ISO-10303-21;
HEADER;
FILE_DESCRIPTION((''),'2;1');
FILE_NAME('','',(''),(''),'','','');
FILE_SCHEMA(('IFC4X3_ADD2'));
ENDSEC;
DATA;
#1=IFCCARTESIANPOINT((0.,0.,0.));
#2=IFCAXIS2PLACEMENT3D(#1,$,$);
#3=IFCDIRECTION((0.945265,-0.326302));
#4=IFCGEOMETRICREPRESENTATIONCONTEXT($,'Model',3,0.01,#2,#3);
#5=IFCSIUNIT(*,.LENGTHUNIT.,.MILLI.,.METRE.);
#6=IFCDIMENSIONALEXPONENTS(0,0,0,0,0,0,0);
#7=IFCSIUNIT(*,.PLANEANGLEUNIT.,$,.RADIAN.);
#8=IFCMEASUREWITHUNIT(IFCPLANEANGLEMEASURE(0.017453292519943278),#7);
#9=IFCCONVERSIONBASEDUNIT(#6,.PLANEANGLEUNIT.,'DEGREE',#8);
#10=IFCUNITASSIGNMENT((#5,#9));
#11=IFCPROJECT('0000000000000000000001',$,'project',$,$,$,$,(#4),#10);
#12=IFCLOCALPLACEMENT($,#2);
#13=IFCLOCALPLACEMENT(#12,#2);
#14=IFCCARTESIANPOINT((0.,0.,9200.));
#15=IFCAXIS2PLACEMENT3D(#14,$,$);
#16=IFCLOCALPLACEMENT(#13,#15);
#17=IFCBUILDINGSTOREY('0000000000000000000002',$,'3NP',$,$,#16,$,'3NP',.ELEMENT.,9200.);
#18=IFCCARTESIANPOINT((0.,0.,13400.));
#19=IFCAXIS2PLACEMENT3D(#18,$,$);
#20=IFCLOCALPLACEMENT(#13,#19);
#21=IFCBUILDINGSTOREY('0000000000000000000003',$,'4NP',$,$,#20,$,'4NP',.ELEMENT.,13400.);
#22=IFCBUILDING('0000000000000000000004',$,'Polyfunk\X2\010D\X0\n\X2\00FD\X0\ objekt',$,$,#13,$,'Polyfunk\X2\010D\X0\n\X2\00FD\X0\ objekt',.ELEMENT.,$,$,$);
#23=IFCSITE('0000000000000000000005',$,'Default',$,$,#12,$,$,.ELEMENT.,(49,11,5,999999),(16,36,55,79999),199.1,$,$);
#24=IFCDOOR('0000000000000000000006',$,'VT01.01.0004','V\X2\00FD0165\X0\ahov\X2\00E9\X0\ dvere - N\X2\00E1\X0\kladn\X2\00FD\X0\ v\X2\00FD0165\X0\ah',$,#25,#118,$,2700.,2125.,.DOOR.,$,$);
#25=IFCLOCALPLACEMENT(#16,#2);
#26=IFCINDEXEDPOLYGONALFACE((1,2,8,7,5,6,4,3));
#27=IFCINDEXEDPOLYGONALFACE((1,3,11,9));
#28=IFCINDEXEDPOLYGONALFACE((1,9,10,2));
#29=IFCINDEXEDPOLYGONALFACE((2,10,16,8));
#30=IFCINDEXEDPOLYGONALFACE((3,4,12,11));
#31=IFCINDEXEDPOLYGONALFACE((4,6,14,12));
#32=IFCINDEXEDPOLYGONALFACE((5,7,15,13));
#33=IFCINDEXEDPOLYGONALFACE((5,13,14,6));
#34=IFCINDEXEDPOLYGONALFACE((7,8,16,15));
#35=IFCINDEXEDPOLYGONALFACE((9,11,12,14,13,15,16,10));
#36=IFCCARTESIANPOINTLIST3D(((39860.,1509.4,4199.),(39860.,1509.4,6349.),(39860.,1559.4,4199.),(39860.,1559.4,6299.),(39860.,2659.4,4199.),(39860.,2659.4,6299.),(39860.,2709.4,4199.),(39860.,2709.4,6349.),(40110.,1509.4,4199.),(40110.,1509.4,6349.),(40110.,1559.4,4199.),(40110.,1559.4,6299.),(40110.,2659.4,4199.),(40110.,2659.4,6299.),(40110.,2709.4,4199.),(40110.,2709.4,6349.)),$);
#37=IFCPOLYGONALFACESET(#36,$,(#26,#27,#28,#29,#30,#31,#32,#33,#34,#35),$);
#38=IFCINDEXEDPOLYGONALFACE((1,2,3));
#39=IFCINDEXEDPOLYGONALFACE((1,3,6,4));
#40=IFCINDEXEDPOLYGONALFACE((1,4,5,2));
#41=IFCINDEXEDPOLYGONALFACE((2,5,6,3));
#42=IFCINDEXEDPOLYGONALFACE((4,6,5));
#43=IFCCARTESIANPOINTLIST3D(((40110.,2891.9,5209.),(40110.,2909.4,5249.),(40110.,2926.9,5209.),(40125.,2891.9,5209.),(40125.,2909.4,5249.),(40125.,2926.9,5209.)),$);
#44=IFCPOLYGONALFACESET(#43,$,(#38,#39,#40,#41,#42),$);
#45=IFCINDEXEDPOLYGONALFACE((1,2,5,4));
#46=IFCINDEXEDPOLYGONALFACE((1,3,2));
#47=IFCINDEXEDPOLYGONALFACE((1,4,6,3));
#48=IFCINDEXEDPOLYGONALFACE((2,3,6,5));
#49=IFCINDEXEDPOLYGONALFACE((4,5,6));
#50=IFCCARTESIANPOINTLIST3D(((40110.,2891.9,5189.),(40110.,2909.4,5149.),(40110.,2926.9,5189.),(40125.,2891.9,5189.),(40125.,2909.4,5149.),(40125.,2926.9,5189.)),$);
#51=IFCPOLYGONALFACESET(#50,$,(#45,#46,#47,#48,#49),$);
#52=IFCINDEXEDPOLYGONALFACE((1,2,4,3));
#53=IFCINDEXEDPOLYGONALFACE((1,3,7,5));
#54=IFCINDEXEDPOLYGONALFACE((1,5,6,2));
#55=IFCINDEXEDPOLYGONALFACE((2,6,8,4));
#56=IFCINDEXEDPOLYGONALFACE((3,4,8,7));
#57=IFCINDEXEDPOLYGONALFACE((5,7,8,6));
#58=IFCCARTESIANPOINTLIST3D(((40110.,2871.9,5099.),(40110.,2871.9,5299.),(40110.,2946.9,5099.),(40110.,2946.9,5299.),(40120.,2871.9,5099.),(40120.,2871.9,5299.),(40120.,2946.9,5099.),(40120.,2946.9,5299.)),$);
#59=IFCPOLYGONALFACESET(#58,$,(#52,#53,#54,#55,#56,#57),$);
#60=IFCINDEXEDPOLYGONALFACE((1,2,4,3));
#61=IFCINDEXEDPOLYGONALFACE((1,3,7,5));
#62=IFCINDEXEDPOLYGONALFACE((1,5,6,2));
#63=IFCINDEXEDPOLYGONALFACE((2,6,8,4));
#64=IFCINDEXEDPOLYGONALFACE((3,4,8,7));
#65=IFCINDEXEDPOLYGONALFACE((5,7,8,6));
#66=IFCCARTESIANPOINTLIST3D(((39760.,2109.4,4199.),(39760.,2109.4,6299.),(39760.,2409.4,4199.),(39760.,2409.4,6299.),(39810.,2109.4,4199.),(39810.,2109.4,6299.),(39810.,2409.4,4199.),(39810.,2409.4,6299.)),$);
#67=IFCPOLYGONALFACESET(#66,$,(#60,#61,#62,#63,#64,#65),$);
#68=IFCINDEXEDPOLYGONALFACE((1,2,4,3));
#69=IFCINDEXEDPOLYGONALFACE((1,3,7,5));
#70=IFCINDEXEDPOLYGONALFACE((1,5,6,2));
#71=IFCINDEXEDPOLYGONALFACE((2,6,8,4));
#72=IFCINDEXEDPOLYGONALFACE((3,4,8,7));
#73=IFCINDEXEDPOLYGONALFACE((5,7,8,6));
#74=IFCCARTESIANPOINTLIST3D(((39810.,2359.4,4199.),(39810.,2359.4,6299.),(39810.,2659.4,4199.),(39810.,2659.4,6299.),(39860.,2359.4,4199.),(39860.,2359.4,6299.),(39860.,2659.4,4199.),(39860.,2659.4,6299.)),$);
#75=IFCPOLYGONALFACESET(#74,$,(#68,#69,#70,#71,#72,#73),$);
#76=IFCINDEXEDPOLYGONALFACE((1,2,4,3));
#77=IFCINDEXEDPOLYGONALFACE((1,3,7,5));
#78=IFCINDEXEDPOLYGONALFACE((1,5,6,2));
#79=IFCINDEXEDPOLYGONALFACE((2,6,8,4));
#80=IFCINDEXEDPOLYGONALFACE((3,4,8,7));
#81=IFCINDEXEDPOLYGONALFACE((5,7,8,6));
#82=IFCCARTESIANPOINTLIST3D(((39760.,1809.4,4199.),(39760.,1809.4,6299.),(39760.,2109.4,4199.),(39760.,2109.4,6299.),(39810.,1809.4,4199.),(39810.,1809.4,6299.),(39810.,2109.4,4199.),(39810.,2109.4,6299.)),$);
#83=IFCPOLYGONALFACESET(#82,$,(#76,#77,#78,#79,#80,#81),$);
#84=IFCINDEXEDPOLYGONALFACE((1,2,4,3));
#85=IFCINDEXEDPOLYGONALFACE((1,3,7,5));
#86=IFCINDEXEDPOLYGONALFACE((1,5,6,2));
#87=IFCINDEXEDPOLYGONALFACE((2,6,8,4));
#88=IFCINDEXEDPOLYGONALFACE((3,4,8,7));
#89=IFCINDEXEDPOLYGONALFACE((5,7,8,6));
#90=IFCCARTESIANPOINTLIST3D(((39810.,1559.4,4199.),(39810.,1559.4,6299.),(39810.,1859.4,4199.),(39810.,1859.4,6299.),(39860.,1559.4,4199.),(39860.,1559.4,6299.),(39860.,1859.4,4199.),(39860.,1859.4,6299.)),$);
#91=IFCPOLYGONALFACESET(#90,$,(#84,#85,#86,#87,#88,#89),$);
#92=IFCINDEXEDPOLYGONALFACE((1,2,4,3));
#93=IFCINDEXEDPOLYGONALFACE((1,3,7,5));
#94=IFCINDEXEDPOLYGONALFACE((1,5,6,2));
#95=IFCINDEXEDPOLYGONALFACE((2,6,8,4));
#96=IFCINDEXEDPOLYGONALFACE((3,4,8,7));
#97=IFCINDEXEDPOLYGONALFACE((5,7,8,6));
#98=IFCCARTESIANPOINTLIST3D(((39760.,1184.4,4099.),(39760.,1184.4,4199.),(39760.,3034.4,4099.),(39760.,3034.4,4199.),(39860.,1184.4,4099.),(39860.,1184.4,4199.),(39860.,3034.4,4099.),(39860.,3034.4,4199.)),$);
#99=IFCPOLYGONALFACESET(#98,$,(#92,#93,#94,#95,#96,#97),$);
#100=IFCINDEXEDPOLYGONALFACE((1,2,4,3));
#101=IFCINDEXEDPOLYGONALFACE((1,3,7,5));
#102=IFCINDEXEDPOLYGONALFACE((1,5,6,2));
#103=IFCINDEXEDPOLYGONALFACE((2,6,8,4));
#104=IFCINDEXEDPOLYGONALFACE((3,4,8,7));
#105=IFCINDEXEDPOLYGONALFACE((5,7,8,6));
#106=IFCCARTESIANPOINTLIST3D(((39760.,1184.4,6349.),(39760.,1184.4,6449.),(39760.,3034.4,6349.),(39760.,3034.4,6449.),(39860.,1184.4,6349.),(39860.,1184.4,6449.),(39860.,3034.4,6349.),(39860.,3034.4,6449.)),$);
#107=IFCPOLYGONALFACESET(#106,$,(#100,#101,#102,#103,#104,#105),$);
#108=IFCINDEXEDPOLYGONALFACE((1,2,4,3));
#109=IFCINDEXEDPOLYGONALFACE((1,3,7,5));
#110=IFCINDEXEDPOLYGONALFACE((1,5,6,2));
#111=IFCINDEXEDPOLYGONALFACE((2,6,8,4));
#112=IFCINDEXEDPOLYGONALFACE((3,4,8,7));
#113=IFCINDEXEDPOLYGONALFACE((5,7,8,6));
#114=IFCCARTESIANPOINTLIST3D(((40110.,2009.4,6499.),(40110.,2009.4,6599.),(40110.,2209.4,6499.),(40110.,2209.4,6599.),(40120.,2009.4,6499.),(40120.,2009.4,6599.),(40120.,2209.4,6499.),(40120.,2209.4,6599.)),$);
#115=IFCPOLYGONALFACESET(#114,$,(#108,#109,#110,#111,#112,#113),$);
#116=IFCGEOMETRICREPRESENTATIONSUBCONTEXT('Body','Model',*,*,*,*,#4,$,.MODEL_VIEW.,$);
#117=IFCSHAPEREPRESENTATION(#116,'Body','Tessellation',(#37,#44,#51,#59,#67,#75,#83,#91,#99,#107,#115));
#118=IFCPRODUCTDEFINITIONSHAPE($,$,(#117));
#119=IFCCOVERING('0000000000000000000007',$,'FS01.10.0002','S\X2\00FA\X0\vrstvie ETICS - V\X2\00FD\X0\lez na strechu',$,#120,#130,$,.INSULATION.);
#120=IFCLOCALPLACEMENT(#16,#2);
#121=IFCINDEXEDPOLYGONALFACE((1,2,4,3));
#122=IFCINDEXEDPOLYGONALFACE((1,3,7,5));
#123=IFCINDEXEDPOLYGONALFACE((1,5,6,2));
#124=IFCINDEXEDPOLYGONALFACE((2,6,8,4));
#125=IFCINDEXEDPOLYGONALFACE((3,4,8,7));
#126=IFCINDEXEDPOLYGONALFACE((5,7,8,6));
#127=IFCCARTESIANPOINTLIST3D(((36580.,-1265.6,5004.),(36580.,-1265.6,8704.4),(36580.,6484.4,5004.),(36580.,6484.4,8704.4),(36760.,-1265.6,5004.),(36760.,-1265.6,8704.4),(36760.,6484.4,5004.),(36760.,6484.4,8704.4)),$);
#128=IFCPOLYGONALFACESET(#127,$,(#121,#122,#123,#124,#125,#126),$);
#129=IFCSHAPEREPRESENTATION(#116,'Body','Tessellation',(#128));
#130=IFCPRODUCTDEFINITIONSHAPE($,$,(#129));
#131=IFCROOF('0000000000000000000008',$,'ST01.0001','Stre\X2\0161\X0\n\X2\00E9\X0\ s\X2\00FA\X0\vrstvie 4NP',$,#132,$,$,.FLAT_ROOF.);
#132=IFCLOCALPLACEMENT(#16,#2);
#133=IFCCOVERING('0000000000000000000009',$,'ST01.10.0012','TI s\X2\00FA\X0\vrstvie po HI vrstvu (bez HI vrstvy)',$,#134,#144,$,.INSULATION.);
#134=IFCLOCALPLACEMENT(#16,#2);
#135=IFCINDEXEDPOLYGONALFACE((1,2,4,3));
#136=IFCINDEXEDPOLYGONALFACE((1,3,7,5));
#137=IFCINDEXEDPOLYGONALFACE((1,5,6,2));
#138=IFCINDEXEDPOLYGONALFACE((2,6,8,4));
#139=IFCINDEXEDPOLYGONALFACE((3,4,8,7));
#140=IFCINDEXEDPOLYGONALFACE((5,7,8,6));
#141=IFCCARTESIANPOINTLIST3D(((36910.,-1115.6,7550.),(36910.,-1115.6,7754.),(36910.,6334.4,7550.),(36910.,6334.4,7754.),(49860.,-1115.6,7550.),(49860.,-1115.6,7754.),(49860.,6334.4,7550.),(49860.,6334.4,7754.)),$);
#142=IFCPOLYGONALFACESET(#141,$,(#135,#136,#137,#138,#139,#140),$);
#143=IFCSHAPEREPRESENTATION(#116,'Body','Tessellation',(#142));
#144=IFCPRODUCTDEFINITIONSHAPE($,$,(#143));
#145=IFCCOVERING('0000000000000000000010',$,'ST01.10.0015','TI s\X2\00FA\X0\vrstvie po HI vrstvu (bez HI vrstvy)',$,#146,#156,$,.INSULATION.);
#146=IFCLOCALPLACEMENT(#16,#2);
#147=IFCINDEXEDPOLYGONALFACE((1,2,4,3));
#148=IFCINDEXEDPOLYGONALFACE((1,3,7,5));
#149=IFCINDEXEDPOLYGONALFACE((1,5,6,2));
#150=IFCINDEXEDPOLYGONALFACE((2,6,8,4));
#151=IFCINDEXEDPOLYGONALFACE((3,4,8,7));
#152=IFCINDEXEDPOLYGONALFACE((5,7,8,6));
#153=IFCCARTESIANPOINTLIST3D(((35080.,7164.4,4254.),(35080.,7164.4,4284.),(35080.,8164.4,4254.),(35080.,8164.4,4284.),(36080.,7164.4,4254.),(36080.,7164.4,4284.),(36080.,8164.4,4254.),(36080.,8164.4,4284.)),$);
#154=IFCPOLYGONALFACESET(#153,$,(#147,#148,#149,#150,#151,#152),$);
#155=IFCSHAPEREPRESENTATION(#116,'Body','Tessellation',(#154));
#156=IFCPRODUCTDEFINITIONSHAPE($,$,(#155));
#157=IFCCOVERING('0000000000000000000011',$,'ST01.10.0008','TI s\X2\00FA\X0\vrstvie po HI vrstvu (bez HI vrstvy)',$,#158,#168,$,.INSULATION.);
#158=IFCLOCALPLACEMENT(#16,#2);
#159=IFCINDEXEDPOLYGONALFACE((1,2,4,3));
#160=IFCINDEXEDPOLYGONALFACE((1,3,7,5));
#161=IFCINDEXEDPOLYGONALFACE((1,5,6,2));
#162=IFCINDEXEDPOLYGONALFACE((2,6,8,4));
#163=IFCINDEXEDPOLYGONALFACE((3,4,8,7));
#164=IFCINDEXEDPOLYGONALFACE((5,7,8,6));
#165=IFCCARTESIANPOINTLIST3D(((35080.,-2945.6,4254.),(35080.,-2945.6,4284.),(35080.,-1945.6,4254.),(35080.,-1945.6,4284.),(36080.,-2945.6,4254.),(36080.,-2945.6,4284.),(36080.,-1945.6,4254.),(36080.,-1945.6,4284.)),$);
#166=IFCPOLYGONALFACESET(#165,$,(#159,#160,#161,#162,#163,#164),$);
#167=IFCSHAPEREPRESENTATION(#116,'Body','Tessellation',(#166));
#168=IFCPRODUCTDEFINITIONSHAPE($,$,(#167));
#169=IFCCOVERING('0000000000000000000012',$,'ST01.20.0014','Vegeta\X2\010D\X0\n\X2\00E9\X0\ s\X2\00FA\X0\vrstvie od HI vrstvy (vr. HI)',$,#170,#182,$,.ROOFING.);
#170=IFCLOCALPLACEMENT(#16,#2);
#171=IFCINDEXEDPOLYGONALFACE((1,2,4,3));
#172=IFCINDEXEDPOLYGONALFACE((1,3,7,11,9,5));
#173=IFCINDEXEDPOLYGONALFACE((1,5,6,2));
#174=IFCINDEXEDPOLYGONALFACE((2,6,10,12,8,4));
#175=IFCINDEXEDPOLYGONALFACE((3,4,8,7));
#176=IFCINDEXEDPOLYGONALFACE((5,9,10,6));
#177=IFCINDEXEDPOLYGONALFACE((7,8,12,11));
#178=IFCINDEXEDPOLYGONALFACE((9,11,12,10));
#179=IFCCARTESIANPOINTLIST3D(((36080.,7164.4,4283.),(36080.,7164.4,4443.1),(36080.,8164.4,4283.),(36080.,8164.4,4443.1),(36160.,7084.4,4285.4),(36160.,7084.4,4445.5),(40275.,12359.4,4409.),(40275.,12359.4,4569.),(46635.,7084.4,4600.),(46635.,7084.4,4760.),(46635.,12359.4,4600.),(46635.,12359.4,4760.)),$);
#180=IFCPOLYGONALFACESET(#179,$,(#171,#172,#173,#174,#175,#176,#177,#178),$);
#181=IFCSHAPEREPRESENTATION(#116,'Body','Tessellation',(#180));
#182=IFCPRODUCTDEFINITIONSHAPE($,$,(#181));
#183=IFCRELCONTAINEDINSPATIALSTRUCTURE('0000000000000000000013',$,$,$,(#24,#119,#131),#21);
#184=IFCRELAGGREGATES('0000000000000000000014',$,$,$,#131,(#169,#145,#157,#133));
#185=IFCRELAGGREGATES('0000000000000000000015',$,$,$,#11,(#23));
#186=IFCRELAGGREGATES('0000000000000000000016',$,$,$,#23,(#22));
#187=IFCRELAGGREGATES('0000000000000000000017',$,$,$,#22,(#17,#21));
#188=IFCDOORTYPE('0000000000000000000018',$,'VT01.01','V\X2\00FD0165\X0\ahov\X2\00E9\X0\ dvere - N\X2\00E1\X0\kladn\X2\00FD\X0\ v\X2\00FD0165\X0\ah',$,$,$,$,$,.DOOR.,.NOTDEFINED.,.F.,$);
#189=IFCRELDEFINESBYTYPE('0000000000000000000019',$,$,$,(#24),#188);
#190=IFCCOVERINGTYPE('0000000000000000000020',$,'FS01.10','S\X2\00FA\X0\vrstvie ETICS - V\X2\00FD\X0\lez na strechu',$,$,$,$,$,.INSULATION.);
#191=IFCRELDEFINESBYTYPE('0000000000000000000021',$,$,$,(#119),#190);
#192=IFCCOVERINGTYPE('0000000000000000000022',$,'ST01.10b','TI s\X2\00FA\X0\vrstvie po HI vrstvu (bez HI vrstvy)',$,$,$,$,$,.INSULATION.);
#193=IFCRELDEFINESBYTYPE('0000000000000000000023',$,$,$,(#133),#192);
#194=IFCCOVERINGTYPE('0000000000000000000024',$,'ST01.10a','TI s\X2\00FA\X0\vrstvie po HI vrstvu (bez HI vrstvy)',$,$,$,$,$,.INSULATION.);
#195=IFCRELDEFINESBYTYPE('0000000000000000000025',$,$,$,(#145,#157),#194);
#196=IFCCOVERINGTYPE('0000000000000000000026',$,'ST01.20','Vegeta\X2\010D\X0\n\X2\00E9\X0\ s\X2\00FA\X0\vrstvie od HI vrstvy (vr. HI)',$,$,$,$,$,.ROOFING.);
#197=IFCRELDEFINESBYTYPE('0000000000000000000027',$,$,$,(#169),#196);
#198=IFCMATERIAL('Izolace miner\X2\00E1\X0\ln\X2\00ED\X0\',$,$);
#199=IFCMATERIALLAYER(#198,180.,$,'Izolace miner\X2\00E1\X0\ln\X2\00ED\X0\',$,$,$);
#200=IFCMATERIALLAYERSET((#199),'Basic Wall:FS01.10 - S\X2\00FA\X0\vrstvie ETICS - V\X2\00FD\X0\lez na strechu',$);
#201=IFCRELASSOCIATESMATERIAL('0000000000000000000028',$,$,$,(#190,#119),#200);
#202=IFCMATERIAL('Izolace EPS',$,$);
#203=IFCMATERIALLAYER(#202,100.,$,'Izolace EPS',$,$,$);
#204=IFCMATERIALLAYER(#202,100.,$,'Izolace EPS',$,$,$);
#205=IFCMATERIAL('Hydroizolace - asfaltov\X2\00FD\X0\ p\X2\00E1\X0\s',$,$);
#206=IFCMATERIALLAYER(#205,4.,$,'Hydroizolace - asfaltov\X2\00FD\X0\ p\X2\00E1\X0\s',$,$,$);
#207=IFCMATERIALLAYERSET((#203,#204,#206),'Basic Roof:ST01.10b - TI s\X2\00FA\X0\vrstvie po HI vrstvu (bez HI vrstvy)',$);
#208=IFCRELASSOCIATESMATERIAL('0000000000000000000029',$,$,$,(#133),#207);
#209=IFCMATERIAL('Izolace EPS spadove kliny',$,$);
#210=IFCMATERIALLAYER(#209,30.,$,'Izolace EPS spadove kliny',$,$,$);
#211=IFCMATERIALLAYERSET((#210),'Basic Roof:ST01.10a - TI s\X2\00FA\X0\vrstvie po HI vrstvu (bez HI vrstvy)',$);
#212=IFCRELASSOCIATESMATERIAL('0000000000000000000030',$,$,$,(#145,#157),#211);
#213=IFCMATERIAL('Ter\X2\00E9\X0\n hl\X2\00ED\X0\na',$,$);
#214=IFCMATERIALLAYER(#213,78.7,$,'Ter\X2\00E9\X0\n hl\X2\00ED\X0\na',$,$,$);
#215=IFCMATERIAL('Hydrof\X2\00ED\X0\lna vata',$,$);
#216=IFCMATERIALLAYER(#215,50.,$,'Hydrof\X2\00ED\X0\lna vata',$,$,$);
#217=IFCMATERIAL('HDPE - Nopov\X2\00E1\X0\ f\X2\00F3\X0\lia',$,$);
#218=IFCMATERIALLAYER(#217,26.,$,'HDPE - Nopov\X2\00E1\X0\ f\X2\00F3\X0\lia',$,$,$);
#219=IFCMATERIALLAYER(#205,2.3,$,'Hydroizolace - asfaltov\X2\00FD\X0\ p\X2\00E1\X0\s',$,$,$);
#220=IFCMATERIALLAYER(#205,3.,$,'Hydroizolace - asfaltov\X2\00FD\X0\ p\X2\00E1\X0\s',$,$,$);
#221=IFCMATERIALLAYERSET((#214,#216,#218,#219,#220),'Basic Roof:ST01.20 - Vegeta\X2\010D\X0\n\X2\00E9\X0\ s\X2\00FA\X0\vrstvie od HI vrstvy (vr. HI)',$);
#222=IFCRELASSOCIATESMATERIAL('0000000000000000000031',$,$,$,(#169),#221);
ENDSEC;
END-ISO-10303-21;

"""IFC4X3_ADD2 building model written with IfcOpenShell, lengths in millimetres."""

from ifc_helpers import new_model, entity, si_unit, converted_unit, direction, frame, frame_2d, origin, origin_2d_with_axis, place, context, subcontext, project, spatial, polyline, rectangle, outline, extrude, source, transform, mapped, material, layer, layer_set, type_object, type_shapes, element, aggregate, save


model = new_model("IFC4X3_ADD2")

# Units and contexts
model_context = context("Model", 3, precision=0.01, world=origin(), true_north=direction((0.945265, -0.326302)))
body_context = subcontext(model_context, "Body", "Model", "MODEL_VIEW")
ifc_project = project(units=[si_unit("LENGTHUNIT", "METRE", prefix="MILLI"), converted_unit("PLANEANGLEUNIT", "DEGREE", entity("IfcPlaneAngleMeasure", 0.017453292519943278), si_unit("PLANEANGLEUNIT", "RADIAN"), dimensions=[0, 0, 0, 0, 0, 0, 0])], contexts=[model_context])

# Site, building, storey
site_placement = place(None, origin())
site = spatial("IfcSite", under=ifc_project, at=site_placement, Name="Default", CompositionType="ELEMENT", RefLatitude=(49, 11, 5, 999999), RefLongitude=(16, 36, 55, 79999), RefElevation=199.1)
building_placement = place(site_placement, origin())
building = spatial("IfcBuilding", under=site, at=building_placement, Name="Polyfunkčný objekt", LongName="Polyfunkčný objekt", CompositionType="ELEMENT")
storey_1_placement = place(building_placement, frame((0.0, 0.0, 9200.0)))
storey_1 = spatial("IfcBuildingStorey", under=building, at=storey_1_placement, Name="3NP", LongName="3NP", CompositionType="ELEMENT", Elevation=9200.0)

# Shared definitions
storey_2_placement = place(building_placement, frame((0.0, 0.0, 13400.0)))
storey_2 = spatial("IfcBuildingStorey", under=building, at=storey_2_placement, Name="4NP", LongName="4NP", CompositionType="ELEMENT", Elevation=13400.0)

# Shared definitions
ifc_material_1 = material(Name="Izolace minerální")

# Door
door_type_1 = type_object("IfcDoorType", Name="VT01.01", Description="Výťahové dvere - Nákladný výťah", OperationType="NOTDEFINED", ParameterTakesPrecedence=False, PredefinedType="DOOR")
shared_shape_1 = source(origin(), body_context, "Body", "SweptSolid", [
    extrude(outline(polyline([(-1087.5, -600.0), (1062.5, -600.0), (1062.5, -550.0), (-1037.5, -550.0), (-1037.5, 550.0), (1062.5, 550.0), (1062.5, 600.0), (-1087.5, 600.0), (-1087.5, -600.0)])), frame((600.0, 0.0, 1062.5), z_axis=(0.0, 1.0, 0.0), x_axis=(0.0, 0.0, -1.0)), (0.0, 0.0, 1.0), 250.0),
    extrude(outline(polyline([(-24.4, -10.7), (19.2, -10.7), (5.2, 21.4), (-24.4, -10.7)])), frame((1400.0, -15.0, 1023.3), z_axis=(0.0, 1.0, 0.0), x_axis=(0.400819, 0.0, -0.916157)), (0.0, 0.0, 1.0), 15.0),
    extrude(outline(polyline([(-24.4, -10.7), (19.2, -10.7), (5.2, 21.4), (-24.4, -10.7)])), frame((1400.0, -15.0, 976.7), z_axis=(0.0, 1.0, 0.0), x_axis=(-0.400819, 0.0, 0.916157)), (0.0, 0.0, 1.0), 15.0),
    extrude(rectangle(XDim=10.0, YDim=75.0, at=frame_2d((0.0, 0.0), x_axis=(1.0, 0.0))), frame((1400.0, -5.0, 900.0), z_axis=(0.0, 0.0, 1.0), x_axis=(0.0, 1.0, 0.0)), (0.0, 0.0, 1.0), 200.0),
    extrude(rectangle(XDim=50.0, YDim=300.0, at=origin_2d_with_axis()), frame((750.0, 325.0, 0.0), z_axis=(0.0, 0.0, 1.0), x_axis=(0.0, -1.0, 0.0)), (0.0, 0.0, 1.0), 2100.0),
    extrude(rectangle(XDim=50.0, YDim=300.0, at=frame_2d((0.0, 0.0), x_axis=(1.0, 0.0))), frame((1000.0, 275.0, 0.0), z_axis=(0.0, 0.0, 1.0), x_axis=(0.0, -1.0, 0.0)), (0.0, 0.0, 1.0), 2100.0),
    extrude(rectangle(XDim=300.0, YDim=50.0, at=frame_2d((0.0, 0.0), x_axis=(1.0, 0.0))), frame((450.0, 325.0, 0.0), z_axis=(0.0, 0.0, 1.0), x_axis=(-1.0, 0.0, 0.0)), (0.0, 0.0, 1.0), 2100.0),
    extrude(rectangle(XDim=300.0, YDim=50.0, at=frame_2d((0.0, 0.0), x_axis=(1.0, 0.0))), frame((200.0, 275.0, 0.0), z_axis=(0.0, 0.0, 1.0), x_axis=(-1.0, 0.0, 0.0)), (0.0, 0.0, 1.0), 2100.0),
    extrude(rectangle(XDim=1850.0, YDim=100.0, at=frame_2d((0.0, 0.0), x_axis=(1.0, 0.0))), frame((600.0, 300.0, -100.0), z_axis=(0.0, 0.0, 1.0), x_axis=(-1.0, 0.0, 0.0)), (0.0, 0.0, 1.0), 100.0),
    extrude(rectangle(XDim=1850.0, YDim=100.0, at=frame_2d((0.0, 0.0), x_axis=(1.0, 0.0))), frame((600.0, 300.0, 2150.0), z_axis=(0.0, 0.0, 1.0), x_axis=(-1.0, 0.0, 0.0)), (0.0, 0.0, 1.0), 100.0),
    extrude(rectangle(XDim=10.0, YDim=200.0, at=frame_2d((0.0, 0.0), x_axis=(1.0, 0.0))), frame((600.0, -5.0, 2300.0), z_axis=(0.0, 0.0, 1.0), x_axis=(0.0, 1.0, 0.0)), (0.0, 0.0, 1.0), 100.0),
])
type_shapes(door_type_1, [shared_shape_1])
door_1_placement = place(storey_2_placement, frame((40110.0, 1509.4, -1.0), z_axis=(0.0, 0.0, 1.0), x_axis=(0.0, 1.0, 0.0)))
element("IfcDoor", 1, at=door_1_placement, inside=storey_2, type_object=door_type_1, Name="VT01.01.0004", Description="Výťahové dvere - Nákladný výťah", OverallHeight=2700.0, OverallWidth=2125.0, PredefinedType="DOOR", context=body_context, shape_type="MappedRepresentation", body=[
    mapped(shared_shape_1, transform((0.0, 0.0, 0.0), scale=1.0)),
])

# Covering
ifc_layer_1 = layer(ifc_material_1, 180.0, Name="Izolace minerální")
ifc_layer_set_1 = layer_set([ifc_layer_1], Name="Basic Wall:FS01.10 - Súvrstvie ETICS - Výlez na strechu")
covering_type_1 = type_object("IfcCoveringType", Name="FS01.10", Description="Súvrstvie ETICS - Výlez na strechu", PredefinedType="INSULATION", material=ifc_layer_set_1)
covering_1_placement = place(storey_2_placement, frame((36670.0, -1265.6, 804.0), z_axis=(0.0, 0.0, 1.0), x_axis=(0.0, 1.0, 0.0)))
element("IfcCovering", 2, at=covering_1_placement, inside=storey_2, type_object=covering_type_1, material=ifc_layer_set_1, Name="FS01.10.0002", Description="Súvrstvie ETICS - Výlez na strechu", PredefinedType="INSULATION", context=body_context, shape_type="SweptSolid", body=[
    extrude(rectangle(XDim=7750.0, YDim=180.0, at=frame_2d((3875.0, 0.0), x_axis=(-1.0, 0.0))), origin(), (0.0, 0.0, 1.0), 3700.4),
])

# Roof, coverings
roof = element("IfcRoof", 3, inside=storey_2, Name="ST01.0001", Description="Strešné súvrstvie 4NP", PredefinedType="FLAT_ROOF")
ifc_material_2 = material(Name="Izolace EPS")
ifc_layer_2 = layer(ifc_material_2, 100.0, Name="Izolace EPS")
ifc_layer_3 = layer(ifc_material_2, 100.0, Name="Izolace EPS")
ifc_material_3 = material(Name="Hydroizolace - asfaltový pás")
ifc_layer_4 = layer(ifc_material_3, 4.0, Name="Hydroizolace - asfaltový pás")
ifc_layer_set_2 = layer_set([ifc_layer_2, ifc_layer_3, ifc_layer_4], Name="Basic Roof:ST01.10b - TI súvrstvie po HI vrstvu (bez HI vrstvy)")
covering_type_2 = type_object("IfcCoveringType", Name="ST01.10b", Description="TI súvrstvie po HI vrstvu (bez HI vrstvy)", PredefinedType="INSULATION")
covering_2_placement = place(storey_2_placement, frame((36910.0, -1115.6, 3350.0)))
covering_2 = element("IfcCovering", 4, at=covering_2_placement, type_object=covering_type_2, material=ifc_layer_set_2, Name="ST01.10.0012", Description="TI súvrstvie po HI vrstvu (bez HI vrstvy)", PredefinedType="INSULATION", context=body_context, shape_type="SweptSolid", body=[
    extrude(rectangle(XDim=7450.0, YDim=12950.0, at=origin_2d_with_axis()), frame((6475.0, 3725.0, 0.0), z_axis=(0.0, 0.0, 1.0), x_axis=(0.0, -1.0, 0.0)), (0.0, 0.0, 1.0), 204.0),
])
ifc_material_4 = material(Name="Izolace EPS spadove kliny")
ifc_layer_5 = layer(ifc_material_4, 30.0, Name="Izolace EPS spadove kliny")
ifc_layer_set_3 = layer_set([ifc_layer_5], Name="Basic Roof:ST01.10a - TI súvrstvie po HI vrstvu (bez HI vrstvy)")
covering_type_3 = type_object("IfcCoveringType", Name="ST01.10a", Description="TI súvrstvie po HI vrstvu (bez HI vrstvy)", PredefinedType="INSULATION")
placement_1 = place(storey_2_placement, frame((35080.0, 7164.4, 54.0)))
covering_3_placement = place(placement_1, origin())
covering_3 = element("IfcCovering", 5, at=covering_3_placement, type_object=covering_type_3, material=ifc_layer_set_3, Name="ST01.10.0015", Description="TI súvrstvie po HI vrstvu (bez HI vrstvy)", PredefinedType="INSULATION", context=body_context, shape_type="SweptSolid", body=[
    extrude(rectangle(XDim=1000.0, YDim=1000.0, at=frame_2d((0.0, 0.0), x_axis=(1.0, 0.0))), frame((500.0, 500.0, 0.0)), (0.0, 0.0, 1.0), 30.0),
])
covering_4_placement = place(storey_2_placement, frame((35080.0, -2945.6, 54.0)))
covering_4 = element("IfcCovering", 6, at=covering_4_placement, type_object=covering_type_3, material=ifc_layer_set_3, Name="ST01.10.0008", Description="TI súvrstvie po HI vrstvu (bez HI vrstvy)", PredefinedType="INSULATION", context=body_context, shape_type="SweptSolid", body=[
    extrude(rectangle(XDim=1000.0, YDim=1000.0, at=frame_2d((0.0, 0.0), x_axis=(1.0, 0.0))), frame((500.0, 500.0, 0.0), z_axis=(0.0, 0.0, 1.0), x_axis=(0.0, 1.0, 0.0)), (0.0, 0.0, 1.0), 30.0),
])
ifc_material_5 = material(Name="Terén hlína")
ifc_layer_6 = layer(ifc_material_5, 78.7, Name="Terén hlína")
ifc_material_6 = material(Name="Hydrofílna vata")
ifc_layer_7 = layer(ifc_material_6, 50.0, Name="Hydrofílna vata")
ifc_material_7 = material(Name="HDPE - Nopová fólia")
ifc_layer_8 = layer(ifc_material_7, 26.0, Name="HDPE - Nopová fólia")
ifc_layer_9 = layer(ifc_material_3, 2.3, Name="Hydroizolace - asfaltový pás")
ifc_layer_10 = layer(ifc_material_3, 3.0, Name="Hydroizolace - asfaltový pás")
ifc_layer_set_4 = layer_set([ifc_layer_6, ifc_layer_7, ifc_layer_8, ifc_layer_9, ifc_layer_10], Name="Basic Roof:ST01.20 - Vegetačné súvrstvie od HI vrstvy (vr. HI)")
covering_type_4 = type_object("IfcCoveringType", Name="ST01.20", Description="Vegetačné súvrstvie od HI vrstvy (vr. HI)", PredefinedType="ROOFING")
placement_2 = place(storey_2_placement, frame((36080.0, 7084.4, 83.0)))
covering_5_placement = place(placement_2, origin())
covering_5 = element("IfcCovering", 7, at=covering_5_placement, type_object=covering_type_4, material=ifc_layer_set_4, Name="ST01.20.0014", Description="Vegetačné súvrstvie od HI vrstvy (vr. HI)", PredefinedType="ROOFING", context=body_context, shape_type="SweptSolid", body=[
    extrude(outline(polyline([(-5279.9, -2557.5), (-5199.8, -2637.5), (5279.9, -2637.5), (5279.9, 2637.5), (-1083.0, 2637.5), (-5279.9, -1557.5), (-5279.9, -2557.5)])), frame((5277.5, 2637.5, 158.5), z_axis=(-0.030015, 0.0, 0.999549), x_axis=(0.999549, 0.0, 0.030015)), (0.030015, 0.0, 0.999549), 160.1),
])
aggregate(roof, [covering_5, covering_3, covering_4, covering_2])

save(model, "model.ifc")
